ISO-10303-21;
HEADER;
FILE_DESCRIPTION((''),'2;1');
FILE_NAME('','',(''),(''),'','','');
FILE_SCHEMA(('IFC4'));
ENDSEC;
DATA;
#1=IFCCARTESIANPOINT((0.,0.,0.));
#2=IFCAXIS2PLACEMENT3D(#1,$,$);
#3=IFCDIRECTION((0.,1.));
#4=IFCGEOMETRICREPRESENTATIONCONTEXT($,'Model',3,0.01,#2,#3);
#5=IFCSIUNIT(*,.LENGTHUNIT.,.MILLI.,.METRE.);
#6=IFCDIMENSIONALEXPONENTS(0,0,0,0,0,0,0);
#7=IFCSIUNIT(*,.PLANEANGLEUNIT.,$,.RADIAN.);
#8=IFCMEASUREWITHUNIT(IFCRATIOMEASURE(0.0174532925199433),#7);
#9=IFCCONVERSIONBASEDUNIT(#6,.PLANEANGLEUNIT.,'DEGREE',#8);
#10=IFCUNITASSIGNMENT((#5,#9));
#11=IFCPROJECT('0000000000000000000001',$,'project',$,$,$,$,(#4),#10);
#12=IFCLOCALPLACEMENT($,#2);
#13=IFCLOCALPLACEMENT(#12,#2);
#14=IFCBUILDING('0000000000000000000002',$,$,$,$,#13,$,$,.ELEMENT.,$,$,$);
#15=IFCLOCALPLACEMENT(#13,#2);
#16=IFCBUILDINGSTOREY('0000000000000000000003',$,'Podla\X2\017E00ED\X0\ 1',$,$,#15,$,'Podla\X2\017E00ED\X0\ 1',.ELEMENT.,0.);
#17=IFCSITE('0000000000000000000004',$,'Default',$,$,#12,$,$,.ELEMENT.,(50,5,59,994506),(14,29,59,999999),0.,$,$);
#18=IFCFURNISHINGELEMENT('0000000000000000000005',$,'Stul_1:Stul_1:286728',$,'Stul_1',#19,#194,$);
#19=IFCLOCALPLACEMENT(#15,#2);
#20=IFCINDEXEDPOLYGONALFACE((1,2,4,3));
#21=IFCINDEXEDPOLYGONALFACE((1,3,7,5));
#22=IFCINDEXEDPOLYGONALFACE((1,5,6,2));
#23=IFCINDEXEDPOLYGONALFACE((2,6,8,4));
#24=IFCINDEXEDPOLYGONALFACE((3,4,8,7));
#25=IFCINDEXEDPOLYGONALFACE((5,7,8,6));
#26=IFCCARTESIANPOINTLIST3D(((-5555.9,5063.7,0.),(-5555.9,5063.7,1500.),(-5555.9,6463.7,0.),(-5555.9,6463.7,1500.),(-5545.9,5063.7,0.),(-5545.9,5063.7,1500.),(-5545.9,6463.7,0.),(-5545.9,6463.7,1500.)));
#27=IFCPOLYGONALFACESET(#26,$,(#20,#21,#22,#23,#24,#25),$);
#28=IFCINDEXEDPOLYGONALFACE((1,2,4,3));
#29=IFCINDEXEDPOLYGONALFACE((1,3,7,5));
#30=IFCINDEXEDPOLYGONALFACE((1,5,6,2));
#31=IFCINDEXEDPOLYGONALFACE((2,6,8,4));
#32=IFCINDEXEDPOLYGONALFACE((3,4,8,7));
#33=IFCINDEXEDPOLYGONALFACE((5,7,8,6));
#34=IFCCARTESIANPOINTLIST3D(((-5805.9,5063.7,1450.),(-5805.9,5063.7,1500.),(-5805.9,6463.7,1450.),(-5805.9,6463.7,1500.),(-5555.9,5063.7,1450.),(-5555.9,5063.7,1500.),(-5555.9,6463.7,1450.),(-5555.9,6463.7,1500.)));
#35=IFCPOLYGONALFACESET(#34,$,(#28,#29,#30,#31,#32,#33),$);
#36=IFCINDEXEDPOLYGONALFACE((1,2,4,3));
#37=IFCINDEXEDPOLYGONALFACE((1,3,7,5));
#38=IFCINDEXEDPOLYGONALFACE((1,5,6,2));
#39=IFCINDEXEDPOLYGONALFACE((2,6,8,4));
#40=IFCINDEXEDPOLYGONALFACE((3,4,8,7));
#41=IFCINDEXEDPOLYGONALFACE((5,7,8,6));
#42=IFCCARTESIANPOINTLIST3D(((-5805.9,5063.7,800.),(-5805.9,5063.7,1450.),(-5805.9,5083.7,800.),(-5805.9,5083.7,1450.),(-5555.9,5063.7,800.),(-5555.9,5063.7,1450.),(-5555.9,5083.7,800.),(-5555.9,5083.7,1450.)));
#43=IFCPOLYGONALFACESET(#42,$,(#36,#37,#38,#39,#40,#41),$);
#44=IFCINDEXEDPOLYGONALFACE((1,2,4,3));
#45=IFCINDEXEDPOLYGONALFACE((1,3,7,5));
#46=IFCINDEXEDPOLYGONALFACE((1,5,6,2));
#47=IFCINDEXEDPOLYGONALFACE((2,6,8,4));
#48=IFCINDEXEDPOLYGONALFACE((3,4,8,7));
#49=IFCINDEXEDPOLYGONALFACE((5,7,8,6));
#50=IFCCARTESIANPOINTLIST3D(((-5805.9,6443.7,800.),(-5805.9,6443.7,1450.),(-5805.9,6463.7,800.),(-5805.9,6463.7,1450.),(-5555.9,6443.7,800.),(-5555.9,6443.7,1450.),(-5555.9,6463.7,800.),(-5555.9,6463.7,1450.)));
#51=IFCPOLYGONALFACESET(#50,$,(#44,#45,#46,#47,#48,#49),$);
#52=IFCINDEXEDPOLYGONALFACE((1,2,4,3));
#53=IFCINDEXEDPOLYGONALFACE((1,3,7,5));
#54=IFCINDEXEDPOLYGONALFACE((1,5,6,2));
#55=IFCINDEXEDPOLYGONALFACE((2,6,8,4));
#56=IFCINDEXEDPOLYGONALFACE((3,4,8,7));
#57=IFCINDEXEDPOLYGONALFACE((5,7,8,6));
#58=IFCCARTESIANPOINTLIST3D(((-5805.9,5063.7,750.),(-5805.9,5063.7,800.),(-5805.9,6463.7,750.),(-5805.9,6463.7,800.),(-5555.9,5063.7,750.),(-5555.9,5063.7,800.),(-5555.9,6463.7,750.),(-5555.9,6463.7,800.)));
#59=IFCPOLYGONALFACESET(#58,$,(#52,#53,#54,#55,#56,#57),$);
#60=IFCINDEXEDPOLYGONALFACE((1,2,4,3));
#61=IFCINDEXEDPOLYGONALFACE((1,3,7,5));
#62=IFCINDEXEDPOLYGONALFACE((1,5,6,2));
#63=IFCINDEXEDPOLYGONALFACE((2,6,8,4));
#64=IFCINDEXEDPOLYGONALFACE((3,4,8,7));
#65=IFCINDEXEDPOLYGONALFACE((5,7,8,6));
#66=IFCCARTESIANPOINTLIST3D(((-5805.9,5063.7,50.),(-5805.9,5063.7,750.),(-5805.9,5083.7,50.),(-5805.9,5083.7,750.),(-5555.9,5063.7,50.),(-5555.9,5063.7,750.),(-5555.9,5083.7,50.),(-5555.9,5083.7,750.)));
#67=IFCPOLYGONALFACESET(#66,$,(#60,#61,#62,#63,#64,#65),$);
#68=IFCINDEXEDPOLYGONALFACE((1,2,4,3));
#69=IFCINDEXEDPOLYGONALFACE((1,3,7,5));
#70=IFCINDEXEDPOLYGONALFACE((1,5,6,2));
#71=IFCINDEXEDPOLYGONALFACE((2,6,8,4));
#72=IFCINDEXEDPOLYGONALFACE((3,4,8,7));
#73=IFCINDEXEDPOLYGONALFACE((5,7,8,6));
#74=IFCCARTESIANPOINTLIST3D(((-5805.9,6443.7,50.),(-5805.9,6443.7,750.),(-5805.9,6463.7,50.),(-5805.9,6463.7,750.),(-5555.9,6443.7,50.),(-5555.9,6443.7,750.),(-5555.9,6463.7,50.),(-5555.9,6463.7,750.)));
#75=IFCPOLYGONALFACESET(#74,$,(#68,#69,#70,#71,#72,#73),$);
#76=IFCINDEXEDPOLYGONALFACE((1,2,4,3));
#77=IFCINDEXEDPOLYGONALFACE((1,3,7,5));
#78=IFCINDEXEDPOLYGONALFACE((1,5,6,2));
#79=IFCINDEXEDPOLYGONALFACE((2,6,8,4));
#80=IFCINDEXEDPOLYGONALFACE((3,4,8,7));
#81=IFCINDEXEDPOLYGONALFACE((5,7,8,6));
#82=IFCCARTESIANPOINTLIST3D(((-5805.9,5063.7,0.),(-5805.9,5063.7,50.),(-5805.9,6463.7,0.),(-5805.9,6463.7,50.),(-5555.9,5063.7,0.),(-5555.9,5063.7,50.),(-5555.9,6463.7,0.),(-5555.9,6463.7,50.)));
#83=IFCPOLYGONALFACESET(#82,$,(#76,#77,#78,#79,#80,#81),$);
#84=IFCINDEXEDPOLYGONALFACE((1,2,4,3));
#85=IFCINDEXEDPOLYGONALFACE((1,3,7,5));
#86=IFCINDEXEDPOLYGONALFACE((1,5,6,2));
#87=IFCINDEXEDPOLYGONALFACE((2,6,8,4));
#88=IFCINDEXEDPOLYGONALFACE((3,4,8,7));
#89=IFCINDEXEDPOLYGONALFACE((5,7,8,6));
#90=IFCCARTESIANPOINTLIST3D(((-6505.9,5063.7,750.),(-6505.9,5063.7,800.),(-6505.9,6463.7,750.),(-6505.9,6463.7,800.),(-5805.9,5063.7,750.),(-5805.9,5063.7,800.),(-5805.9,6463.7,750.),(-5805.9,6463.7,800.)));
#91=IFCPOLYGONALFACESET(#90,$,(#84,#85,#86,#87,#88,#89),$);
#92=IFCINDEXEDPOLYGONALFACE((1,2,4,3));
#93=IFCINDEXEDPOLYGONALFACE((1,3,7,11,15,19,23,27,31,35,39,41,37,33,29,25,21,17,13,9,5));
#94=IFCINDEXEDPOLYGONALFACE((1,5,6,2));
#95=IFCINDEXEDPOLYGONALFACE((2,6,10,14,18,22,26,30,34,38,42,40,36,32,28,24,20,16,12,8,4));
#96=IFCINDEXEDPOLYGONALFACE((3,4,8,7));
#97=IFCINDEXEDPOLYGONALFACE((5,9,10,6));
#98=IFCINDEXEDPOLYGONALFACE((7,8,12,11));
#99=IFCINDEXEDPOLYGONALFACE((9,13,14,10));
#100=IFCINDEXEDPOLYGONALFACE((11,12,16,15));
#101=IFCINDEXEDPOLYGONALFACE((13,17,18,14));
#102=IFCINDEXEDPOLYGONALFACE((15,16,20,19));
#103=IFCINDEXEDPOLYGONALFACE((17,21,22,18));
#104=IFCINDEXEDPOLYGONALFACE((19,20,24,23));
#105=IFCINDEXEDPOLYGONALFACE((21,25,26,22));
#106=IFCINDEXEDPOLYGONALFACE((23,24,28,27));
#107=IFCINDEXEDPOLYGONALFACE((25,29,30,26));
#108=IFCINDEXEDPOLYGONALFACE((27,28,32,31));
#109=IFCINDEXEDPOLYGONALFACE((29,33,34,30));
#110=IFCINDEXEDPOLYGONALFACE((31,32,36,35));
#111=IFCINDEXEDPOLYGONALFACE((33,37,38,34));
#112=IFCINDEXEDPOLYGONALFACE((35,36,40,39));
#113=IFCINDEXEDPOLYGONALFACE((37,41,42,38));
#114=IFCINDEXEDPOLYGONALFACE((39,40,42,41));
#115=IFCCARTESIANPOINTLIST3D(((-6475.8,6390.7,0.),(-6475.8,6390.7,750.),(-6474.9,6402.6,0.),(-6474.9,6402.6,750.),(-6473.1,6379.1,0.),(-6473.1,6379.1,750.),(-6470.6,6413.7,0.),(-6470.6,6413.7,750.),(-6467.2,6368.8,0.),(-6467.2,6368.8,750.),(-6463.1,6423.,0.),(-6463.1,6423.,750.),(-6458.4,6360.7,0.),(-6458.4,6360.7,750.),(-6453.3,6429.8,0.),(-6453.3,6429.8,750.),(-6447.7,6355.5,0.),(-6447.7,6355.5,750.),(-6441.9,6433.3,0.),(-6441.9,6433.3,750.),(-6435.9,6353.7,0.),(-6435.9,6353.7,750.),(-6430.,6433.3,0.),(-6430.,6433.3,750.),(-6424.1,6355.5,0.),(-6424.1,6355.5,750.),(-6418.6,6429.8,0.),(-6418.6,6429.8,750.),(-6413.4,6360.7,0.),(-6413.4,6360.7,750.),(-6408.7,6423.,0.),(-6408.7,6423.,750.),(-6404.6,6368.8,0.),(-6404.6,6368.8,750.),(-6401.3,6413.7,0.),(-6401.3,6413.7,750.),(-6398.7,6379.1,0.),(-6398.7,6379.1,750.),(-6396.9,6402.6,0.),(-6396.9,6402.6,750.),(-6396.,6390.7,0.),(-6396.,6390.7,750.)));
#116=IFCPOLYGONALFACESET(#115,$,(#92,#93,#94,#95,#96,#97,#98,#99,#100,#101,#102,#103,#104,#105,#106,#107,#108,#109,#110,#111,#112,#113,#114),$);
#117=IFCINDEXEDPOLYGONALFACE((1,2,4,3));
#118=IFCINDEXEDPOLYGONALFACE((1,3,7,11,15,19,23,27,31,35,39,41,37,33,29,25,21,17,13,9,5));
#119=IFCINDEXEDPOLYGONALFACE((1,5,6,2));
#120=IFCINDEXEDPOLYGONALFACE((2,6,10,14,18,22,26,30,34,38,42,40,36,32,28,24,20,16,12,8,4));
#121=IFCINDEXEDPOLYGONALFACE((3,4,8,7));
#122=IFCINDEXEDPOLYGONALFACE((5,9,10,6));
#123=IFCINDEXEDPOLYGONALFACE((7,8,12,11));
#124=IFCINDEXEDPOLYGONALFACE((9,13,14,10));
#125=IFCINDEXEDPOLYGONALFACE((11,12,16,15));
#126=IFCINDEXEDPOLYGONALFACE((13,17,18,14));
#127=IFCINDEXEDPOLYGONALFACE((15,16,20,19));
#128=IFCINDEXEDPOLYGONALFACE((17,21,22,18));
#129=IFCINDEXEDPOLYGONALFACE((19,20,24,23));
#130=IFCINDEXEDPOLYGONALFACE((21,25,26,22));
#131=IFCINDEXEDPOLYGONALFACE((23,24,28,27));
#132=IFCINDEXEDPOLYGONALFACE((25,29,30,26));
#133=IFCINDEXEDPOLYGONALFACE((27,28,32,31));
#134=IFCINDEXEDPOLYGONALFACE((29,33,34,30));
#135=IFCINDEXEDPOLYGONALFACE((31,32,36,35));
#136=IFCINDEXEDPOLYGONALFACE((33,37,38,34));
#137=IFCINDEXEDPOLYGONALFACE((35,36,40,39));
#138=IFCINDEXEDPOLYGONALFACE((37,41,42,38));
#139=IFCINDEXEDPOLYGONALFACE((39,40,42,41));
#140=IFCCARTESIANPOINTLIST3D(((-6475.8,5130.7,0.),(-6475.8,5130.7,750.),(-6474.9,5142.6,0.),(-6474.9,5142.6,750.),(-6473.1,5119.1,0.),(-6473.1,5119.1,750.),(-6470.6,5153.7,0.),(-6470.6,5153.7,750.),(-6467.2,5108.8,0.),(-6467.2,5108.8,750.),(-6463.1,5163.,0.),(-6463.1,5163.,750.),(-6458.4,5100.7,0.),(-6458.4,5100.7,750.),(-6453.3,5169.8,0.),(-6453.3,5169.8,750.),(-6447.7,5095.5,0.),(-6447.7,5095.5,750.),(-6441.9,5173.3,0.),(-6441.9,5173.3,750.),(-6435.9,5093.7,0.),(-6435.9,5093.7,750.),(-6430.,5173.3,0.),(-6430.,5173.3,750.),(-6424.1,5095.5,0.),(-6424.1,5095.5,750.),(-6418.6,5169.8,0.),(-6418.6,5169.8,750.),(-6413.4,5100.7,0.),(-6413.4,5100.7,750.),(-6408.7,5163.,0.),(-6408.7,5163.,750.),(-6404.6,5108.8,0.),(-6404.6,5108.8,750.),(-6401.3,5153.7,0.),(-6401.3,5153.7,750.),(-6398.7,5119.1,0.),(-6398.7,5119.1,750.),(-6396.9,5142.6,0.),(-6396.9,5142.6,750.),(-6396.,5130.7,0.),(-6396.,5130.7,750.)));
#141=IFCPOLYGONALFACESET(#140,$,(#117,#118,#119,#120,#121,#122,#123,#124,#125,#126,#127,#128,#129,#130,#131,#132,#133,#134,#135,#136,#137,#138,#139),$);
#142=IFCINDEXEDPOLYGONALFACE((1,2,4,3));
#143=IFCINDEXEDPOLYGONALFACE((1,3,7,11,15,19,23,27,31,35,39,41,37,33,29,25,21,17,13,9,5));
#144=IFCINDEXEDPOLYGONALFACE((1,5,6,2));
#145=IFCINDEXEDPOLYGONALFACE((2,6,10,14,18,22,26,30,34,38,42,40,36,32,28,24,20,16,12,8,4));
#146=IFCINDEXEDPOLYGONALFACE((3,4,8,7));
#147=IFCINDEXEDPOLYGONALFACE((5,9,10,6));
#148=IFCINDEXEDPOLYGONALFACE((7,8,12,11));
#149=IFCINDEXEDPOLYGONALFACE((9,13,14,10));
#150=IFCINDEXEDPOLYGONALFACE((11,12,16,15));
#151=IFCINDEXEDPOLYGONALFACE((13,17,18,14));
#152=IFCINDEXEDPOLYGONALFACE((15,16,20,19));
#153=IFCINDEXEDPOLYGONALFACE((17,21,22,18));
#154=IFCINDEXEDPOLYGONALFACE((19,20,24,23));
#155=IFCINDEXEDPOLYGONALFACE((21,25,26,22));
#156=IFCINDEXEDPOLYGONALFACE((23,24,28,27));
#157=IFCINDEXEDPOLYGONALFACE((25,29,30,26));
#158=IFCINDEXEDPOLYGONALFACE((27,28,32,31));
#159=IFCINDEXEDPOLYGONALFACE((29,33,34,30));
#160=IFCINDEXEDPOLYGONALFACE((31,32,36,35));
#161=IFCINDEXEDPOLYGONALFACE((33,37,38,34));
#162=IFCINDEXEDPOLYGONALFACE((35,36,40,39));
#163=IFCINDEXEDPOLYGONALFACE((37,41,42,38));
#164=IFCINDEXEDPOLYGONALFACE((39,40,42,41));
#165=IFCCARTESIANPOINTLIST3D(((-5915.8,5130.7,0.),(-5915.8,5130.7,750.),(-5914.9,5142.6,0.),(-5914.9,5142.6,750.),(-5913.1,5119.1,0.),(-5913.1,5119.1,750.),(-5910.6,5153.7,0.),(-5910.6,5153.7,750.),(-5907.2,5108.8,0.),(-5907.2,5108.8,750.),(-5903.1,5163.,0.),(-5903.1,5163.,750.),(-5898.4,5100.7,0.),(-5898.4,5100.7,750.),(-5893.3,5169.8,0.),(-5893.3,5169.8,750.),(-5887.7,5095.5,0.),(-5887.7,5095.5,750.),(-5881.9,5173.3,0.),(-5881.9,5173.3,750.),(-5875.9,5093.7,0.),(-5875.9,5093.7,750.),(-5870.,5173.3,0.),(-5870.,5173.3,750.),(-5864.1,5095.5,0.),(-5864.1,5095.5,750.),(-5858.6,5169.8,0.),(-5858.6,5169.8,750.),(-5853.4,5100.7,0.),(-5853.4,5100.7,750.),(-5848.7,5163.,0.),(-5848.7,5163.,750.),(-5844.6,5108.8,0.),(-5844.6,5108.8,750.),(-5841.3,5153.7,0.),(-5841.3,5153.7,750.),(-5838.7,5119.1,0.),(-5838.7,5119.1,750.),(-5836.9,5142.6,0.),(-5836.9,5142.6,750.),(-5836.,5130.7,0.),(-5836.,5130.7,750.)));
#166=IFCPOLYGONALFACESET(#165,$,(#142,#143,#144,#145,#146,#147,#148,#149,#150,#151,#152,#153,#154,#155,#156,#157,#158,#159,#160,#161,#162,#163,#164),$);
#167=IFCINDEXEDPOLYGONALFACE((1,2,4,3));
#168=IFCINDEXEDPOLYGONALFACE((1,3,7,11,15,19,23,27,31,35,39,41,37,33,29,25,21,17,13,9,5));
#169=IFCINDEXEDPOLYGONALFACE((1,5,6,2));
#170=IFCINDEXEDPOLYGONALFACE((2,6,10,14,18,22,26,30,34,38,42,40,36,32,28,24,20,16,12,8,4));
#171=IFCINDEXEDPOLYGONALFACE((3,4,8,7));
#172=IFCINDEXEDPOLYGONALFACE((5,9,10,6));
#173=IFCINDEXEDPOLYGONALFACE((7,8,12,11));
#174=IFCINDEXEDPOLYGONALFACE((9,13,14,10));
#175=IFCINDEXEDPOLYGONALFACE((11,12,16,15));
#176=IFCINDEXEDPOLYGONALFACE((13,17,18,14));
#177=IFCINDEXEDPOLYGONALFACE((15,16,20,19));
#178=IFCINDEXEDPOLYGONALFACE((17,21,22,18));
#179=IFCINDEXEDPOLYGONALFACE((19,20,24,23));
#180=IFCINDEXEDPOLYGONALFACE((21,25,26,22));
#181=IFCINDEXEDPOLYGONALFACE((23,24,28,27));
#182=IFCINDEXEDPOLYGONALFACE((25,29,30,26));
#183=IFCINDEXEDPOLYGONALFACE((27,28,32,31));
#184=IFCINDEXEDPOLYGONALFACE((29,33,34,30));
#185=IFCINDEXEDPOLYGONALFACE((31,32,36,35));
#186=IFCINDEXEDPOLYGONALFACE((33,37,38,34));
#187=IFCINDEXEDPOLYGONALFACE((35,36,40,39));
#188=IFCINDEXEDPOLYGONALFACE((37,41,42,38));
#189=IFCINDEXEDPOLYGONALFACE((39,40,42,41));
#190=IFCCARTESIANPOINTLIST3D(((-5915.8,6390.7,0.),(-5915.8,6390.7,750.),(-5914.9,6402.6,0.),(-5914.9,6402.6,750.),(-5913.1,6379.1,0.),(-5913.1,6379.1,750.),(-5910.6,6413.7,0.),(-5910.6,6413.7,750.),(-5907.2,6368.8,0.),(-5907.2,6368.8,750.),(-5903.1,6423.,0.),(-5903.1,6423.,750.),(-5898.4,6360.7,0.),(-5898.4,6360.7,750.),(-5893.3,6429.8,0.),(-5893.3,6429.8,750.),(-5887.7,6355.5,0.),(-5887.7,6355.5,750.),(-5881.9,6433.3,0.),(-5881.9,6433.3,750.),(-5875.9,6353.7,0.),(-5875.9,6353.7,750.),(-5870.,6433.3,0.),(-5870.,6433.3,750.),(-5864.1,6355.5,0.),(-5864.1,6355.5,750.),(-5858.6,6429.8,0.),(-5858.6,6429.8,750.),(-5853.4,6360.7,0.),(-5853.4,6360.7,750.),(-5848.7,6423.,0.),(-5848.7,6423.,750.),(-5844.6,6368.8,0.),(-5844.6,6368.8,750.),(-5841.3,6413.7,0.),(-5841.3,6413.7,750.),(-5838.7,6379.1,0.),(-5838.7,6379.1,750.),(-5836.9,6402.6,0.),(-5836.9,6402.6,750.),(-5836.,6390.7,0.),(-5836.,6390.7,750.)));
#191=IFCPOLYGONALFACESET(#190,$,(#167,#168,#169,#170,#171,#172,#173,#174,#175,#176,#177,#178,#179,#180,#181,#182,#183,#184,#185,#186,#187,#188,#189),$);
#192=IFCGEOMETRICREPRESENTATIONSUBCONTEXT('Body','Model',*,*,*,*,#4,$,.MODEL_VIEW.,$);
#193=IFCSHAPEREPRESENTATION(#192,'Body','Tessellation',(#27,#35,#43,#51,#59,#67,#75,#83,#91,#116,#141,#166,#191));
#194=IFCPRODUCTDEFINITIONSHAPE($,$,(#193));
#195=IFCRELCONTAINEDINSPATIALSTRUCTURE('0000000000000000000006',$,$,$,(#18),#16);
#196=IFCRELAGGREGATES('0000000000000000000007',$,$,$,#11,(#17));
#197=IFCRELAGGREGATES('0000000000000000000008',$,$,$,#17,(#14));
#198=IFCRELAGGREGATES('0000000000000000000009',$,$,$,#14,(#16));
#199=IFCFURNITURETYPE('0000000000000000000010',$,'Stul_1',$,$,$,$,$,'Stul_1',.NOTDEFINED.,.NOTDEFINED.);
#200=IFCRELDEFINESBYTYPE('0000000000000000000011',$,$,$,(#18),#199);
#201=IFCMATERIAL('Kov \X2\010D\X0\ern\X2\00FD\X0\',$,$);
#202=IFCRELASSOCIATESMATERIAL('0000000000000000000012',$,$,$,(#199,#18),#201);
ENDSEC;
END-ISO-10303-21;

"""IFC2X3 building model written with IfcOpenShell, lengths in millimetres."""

from ifc_helpers import new_model, entity, si_unit, converted_unit, direction, frame, frame_2d, origin, origin_2d_with_axis, place, context, subcontext, project, spatial, rectangle, circle, extrude, source, transform, mapped, material, type_object, type_shapes, element, save


model = new_model("IFC2X3")

# Units and contexts
model_context = context("Model", 3, precision=0.01, world=origin(), true_north=direction((0.0, 1.0)))
body_context = subcontext(model_context, "Body", "Model", "MODEL_VIEW")
ifc_project = project(units=[si_unit("LENGTHUNIT", "METRE", prefix="MILLI"), converted_unit("PLANEANGLEUNIT", "DEGREE", entity("IfcRatioMeasure", 0.0174532925199433), si_unit("PLANEANGLEUNIT", "RADIAN"), dimensions=[0, 0, 0, 0, 0, 0, 0])], contexts=[model_context])

# Site, building, storey
site_placement = place(None, origin())
site = spatial("IfcSite", under=ifc_project, at=site_placement, Name="Default", CompositionType="ELEMENT", RefLatitude=(50, 5, 59, 994506), RefLongitude=(14, 29, 59, 999999), RefElevation=0.0)
building_placement = place(site_placement, origin())
building = spatial("IfcBuilding", under=site, at=building_placement, CompositionType="ELEMENT")
storey_placement = place(building_placement, origin())
storey = spatial("IfcBuildingStorey", under=building, at=storey_placement, Name="Podlaží 1", LongName="Podlaží 1", CompositionType="ELEMENT", Elevation=0.0)

# Furnishing element
ifc_material_1 = material(Name="Kov černý")
furniture_type = type_object("IfcFurnitureType", Name="Stul_1", ElementType="Stul_1", material=ifc_material_1)
shared_shape_1 = source(origin(), body_context, "Body", "SweptSolid", [
    extrude(rectangle(XDim=1400.0, YDim=10.0, at=origin_2d_with_axis()), frame((0.0, 605.0, 0.0), z_axis=(0.0, 0.0, 1.0), x_axis=(-1.0, 0.0, 0.0)), (0.0, 0.0, 1.0), 1500.0),
    extrude(rectangle(XDim=1400.0, YDim=250.0, at=frame_2d((0.0, 0.0), x_axis=(1.0, 0.0))), frame((0.0, 475.0, 1450.0), z_axis=(0.0, 0.0, 1.0), x_axis=(-1.0, 0.0, 0.0)), (0.0, 0.0, 1.0), 50.0),
    extrude(rectangle(XDim=20.0, YDim=250.0, at=origin_2d_with_axis()), frame((690.0, 475.0, 800.0), z_axis=(0.0, 0.0, 1.0), x_axis=(-1.0, 0.0, 0.0)), (0.0, 0.0, 1.0), 650.0),
    extrude(rectangle(XDim=20.0, YDim=250.0, at=frame_2d((0.0, 0.0), x_axis=(1.0, 0.0))), frame((-690.0, 475.0, 800.0), z_axis=(0.0, 0.0, 1.0), x_axis=(-1.0, 0.0, 0.0)), (0.0, 0.0, 1.0), 650.0),
    extrude(rectangle(XDim=1400.0, YDim=250.0, at=origin_2d_with_axis()), frame((0.0, 475.0, 750.0), z_axis=(0.0, 0.0, 1.0), x_axis=(-1.0, 0.0, 0.0)), (0.0, 0.0, 1.0), 50.0),
    extrude(rectangle(XDim=20.0, YDim=250.0, at=origin_2d_with_axis()), frame((690.0, 475.0, 50.0), z_axis=(0.0, 0.0, 1.0), x_axis=(-1.0, 0.0, 0.0)), (0.0, 0.0, 1.0), 700.0),
    extrude(rectangle(XDim=20.0, YDim=250.0, at=frame_2d((0.0, 0.0), x_axis=(1.0, 0.0))), frame((-690.0, 475.0, 50.0), z_axis=(0.0, 0.0, 1.0), x_axis=(-1.0, 0.0, 0.0)), (0.0, 0.0, 1.0), 700.0),
    extrude(rectangle(XDim=1400.0, YDim=250.0, at=origin_2d_with_axis()), frame((0.0, 475.0, 0.0), z_axis=(0.0, 0.0, 1.0), x_axis=(-1.0, 0.0, 0.0)), (0.0, 0.0, 1.0), 50.0),
    extrude(rectangle(XDim=1400.0, YDim=700.0, at=origin_2d_with_axis()), frame((0.0, 0.0, 750.0), z_axis=(0.0, 0.0, 1.0), x_axis=(-1.0, 0.0, 0.0)), (0.0, 0.0, 1.0), 50.0),
    extrude(circle(Radius=40.0, at=frame_2d((0.0, 0.0), x_axis=(1.0, 0.0))), frame((-630.0, -280.0, 0.0)), (0.0, 0.0, 1.0), 750.0),
    extrude(circle(Radius=40.0, at=frame_2d((0.0, 0.0), x_axis=(1.0, 0.0))), frame((630.0, -280.0, 0.0)), (0.0, 0.0, 1.0), 750.0),
    extrude(circle(Radius=40.0, at=frame_2d((0.0, 0.0), x_axis=(1.0, 0.0))), frame((630.0, 280.0, 0.0)), (0.0, 0.0, 1.0), 750.0),
    extrude(circle(Radius=40.0, at=frame_2d((0.0, 0.0), x_axis=(1.0, 0.0))), frame((-630.0, 280.0, 0.0)), (0.0, 0.0, 1.0), 750.0),
])
type_shapes(furniture_type, [shared_shape_1])
for number, where, z_axis, x_axis, name in (
    (1, (-6155.9, 5763.7, 0.0), (0.0, 0.0, 1.0), (0.0, -1.0, 0.0), "Stul_1:Stul_1:286728"),
):
    element("IfcFurnishingElement", number, at=place(storey_placement, frame(where, z_axis=z_axis, x_axis=x_axis)), inside=storey, type_object=furniture_type, material=ifc_material_1, Name=name, ObjectType="Stul_1", context=body_context, shape_type="MappedRepresentation", body=[
        mapped(shared_shape_1, transform((0.0, 0.0, 0.0), scale=1.0)),
    ])

save(model, "model.ifc")
